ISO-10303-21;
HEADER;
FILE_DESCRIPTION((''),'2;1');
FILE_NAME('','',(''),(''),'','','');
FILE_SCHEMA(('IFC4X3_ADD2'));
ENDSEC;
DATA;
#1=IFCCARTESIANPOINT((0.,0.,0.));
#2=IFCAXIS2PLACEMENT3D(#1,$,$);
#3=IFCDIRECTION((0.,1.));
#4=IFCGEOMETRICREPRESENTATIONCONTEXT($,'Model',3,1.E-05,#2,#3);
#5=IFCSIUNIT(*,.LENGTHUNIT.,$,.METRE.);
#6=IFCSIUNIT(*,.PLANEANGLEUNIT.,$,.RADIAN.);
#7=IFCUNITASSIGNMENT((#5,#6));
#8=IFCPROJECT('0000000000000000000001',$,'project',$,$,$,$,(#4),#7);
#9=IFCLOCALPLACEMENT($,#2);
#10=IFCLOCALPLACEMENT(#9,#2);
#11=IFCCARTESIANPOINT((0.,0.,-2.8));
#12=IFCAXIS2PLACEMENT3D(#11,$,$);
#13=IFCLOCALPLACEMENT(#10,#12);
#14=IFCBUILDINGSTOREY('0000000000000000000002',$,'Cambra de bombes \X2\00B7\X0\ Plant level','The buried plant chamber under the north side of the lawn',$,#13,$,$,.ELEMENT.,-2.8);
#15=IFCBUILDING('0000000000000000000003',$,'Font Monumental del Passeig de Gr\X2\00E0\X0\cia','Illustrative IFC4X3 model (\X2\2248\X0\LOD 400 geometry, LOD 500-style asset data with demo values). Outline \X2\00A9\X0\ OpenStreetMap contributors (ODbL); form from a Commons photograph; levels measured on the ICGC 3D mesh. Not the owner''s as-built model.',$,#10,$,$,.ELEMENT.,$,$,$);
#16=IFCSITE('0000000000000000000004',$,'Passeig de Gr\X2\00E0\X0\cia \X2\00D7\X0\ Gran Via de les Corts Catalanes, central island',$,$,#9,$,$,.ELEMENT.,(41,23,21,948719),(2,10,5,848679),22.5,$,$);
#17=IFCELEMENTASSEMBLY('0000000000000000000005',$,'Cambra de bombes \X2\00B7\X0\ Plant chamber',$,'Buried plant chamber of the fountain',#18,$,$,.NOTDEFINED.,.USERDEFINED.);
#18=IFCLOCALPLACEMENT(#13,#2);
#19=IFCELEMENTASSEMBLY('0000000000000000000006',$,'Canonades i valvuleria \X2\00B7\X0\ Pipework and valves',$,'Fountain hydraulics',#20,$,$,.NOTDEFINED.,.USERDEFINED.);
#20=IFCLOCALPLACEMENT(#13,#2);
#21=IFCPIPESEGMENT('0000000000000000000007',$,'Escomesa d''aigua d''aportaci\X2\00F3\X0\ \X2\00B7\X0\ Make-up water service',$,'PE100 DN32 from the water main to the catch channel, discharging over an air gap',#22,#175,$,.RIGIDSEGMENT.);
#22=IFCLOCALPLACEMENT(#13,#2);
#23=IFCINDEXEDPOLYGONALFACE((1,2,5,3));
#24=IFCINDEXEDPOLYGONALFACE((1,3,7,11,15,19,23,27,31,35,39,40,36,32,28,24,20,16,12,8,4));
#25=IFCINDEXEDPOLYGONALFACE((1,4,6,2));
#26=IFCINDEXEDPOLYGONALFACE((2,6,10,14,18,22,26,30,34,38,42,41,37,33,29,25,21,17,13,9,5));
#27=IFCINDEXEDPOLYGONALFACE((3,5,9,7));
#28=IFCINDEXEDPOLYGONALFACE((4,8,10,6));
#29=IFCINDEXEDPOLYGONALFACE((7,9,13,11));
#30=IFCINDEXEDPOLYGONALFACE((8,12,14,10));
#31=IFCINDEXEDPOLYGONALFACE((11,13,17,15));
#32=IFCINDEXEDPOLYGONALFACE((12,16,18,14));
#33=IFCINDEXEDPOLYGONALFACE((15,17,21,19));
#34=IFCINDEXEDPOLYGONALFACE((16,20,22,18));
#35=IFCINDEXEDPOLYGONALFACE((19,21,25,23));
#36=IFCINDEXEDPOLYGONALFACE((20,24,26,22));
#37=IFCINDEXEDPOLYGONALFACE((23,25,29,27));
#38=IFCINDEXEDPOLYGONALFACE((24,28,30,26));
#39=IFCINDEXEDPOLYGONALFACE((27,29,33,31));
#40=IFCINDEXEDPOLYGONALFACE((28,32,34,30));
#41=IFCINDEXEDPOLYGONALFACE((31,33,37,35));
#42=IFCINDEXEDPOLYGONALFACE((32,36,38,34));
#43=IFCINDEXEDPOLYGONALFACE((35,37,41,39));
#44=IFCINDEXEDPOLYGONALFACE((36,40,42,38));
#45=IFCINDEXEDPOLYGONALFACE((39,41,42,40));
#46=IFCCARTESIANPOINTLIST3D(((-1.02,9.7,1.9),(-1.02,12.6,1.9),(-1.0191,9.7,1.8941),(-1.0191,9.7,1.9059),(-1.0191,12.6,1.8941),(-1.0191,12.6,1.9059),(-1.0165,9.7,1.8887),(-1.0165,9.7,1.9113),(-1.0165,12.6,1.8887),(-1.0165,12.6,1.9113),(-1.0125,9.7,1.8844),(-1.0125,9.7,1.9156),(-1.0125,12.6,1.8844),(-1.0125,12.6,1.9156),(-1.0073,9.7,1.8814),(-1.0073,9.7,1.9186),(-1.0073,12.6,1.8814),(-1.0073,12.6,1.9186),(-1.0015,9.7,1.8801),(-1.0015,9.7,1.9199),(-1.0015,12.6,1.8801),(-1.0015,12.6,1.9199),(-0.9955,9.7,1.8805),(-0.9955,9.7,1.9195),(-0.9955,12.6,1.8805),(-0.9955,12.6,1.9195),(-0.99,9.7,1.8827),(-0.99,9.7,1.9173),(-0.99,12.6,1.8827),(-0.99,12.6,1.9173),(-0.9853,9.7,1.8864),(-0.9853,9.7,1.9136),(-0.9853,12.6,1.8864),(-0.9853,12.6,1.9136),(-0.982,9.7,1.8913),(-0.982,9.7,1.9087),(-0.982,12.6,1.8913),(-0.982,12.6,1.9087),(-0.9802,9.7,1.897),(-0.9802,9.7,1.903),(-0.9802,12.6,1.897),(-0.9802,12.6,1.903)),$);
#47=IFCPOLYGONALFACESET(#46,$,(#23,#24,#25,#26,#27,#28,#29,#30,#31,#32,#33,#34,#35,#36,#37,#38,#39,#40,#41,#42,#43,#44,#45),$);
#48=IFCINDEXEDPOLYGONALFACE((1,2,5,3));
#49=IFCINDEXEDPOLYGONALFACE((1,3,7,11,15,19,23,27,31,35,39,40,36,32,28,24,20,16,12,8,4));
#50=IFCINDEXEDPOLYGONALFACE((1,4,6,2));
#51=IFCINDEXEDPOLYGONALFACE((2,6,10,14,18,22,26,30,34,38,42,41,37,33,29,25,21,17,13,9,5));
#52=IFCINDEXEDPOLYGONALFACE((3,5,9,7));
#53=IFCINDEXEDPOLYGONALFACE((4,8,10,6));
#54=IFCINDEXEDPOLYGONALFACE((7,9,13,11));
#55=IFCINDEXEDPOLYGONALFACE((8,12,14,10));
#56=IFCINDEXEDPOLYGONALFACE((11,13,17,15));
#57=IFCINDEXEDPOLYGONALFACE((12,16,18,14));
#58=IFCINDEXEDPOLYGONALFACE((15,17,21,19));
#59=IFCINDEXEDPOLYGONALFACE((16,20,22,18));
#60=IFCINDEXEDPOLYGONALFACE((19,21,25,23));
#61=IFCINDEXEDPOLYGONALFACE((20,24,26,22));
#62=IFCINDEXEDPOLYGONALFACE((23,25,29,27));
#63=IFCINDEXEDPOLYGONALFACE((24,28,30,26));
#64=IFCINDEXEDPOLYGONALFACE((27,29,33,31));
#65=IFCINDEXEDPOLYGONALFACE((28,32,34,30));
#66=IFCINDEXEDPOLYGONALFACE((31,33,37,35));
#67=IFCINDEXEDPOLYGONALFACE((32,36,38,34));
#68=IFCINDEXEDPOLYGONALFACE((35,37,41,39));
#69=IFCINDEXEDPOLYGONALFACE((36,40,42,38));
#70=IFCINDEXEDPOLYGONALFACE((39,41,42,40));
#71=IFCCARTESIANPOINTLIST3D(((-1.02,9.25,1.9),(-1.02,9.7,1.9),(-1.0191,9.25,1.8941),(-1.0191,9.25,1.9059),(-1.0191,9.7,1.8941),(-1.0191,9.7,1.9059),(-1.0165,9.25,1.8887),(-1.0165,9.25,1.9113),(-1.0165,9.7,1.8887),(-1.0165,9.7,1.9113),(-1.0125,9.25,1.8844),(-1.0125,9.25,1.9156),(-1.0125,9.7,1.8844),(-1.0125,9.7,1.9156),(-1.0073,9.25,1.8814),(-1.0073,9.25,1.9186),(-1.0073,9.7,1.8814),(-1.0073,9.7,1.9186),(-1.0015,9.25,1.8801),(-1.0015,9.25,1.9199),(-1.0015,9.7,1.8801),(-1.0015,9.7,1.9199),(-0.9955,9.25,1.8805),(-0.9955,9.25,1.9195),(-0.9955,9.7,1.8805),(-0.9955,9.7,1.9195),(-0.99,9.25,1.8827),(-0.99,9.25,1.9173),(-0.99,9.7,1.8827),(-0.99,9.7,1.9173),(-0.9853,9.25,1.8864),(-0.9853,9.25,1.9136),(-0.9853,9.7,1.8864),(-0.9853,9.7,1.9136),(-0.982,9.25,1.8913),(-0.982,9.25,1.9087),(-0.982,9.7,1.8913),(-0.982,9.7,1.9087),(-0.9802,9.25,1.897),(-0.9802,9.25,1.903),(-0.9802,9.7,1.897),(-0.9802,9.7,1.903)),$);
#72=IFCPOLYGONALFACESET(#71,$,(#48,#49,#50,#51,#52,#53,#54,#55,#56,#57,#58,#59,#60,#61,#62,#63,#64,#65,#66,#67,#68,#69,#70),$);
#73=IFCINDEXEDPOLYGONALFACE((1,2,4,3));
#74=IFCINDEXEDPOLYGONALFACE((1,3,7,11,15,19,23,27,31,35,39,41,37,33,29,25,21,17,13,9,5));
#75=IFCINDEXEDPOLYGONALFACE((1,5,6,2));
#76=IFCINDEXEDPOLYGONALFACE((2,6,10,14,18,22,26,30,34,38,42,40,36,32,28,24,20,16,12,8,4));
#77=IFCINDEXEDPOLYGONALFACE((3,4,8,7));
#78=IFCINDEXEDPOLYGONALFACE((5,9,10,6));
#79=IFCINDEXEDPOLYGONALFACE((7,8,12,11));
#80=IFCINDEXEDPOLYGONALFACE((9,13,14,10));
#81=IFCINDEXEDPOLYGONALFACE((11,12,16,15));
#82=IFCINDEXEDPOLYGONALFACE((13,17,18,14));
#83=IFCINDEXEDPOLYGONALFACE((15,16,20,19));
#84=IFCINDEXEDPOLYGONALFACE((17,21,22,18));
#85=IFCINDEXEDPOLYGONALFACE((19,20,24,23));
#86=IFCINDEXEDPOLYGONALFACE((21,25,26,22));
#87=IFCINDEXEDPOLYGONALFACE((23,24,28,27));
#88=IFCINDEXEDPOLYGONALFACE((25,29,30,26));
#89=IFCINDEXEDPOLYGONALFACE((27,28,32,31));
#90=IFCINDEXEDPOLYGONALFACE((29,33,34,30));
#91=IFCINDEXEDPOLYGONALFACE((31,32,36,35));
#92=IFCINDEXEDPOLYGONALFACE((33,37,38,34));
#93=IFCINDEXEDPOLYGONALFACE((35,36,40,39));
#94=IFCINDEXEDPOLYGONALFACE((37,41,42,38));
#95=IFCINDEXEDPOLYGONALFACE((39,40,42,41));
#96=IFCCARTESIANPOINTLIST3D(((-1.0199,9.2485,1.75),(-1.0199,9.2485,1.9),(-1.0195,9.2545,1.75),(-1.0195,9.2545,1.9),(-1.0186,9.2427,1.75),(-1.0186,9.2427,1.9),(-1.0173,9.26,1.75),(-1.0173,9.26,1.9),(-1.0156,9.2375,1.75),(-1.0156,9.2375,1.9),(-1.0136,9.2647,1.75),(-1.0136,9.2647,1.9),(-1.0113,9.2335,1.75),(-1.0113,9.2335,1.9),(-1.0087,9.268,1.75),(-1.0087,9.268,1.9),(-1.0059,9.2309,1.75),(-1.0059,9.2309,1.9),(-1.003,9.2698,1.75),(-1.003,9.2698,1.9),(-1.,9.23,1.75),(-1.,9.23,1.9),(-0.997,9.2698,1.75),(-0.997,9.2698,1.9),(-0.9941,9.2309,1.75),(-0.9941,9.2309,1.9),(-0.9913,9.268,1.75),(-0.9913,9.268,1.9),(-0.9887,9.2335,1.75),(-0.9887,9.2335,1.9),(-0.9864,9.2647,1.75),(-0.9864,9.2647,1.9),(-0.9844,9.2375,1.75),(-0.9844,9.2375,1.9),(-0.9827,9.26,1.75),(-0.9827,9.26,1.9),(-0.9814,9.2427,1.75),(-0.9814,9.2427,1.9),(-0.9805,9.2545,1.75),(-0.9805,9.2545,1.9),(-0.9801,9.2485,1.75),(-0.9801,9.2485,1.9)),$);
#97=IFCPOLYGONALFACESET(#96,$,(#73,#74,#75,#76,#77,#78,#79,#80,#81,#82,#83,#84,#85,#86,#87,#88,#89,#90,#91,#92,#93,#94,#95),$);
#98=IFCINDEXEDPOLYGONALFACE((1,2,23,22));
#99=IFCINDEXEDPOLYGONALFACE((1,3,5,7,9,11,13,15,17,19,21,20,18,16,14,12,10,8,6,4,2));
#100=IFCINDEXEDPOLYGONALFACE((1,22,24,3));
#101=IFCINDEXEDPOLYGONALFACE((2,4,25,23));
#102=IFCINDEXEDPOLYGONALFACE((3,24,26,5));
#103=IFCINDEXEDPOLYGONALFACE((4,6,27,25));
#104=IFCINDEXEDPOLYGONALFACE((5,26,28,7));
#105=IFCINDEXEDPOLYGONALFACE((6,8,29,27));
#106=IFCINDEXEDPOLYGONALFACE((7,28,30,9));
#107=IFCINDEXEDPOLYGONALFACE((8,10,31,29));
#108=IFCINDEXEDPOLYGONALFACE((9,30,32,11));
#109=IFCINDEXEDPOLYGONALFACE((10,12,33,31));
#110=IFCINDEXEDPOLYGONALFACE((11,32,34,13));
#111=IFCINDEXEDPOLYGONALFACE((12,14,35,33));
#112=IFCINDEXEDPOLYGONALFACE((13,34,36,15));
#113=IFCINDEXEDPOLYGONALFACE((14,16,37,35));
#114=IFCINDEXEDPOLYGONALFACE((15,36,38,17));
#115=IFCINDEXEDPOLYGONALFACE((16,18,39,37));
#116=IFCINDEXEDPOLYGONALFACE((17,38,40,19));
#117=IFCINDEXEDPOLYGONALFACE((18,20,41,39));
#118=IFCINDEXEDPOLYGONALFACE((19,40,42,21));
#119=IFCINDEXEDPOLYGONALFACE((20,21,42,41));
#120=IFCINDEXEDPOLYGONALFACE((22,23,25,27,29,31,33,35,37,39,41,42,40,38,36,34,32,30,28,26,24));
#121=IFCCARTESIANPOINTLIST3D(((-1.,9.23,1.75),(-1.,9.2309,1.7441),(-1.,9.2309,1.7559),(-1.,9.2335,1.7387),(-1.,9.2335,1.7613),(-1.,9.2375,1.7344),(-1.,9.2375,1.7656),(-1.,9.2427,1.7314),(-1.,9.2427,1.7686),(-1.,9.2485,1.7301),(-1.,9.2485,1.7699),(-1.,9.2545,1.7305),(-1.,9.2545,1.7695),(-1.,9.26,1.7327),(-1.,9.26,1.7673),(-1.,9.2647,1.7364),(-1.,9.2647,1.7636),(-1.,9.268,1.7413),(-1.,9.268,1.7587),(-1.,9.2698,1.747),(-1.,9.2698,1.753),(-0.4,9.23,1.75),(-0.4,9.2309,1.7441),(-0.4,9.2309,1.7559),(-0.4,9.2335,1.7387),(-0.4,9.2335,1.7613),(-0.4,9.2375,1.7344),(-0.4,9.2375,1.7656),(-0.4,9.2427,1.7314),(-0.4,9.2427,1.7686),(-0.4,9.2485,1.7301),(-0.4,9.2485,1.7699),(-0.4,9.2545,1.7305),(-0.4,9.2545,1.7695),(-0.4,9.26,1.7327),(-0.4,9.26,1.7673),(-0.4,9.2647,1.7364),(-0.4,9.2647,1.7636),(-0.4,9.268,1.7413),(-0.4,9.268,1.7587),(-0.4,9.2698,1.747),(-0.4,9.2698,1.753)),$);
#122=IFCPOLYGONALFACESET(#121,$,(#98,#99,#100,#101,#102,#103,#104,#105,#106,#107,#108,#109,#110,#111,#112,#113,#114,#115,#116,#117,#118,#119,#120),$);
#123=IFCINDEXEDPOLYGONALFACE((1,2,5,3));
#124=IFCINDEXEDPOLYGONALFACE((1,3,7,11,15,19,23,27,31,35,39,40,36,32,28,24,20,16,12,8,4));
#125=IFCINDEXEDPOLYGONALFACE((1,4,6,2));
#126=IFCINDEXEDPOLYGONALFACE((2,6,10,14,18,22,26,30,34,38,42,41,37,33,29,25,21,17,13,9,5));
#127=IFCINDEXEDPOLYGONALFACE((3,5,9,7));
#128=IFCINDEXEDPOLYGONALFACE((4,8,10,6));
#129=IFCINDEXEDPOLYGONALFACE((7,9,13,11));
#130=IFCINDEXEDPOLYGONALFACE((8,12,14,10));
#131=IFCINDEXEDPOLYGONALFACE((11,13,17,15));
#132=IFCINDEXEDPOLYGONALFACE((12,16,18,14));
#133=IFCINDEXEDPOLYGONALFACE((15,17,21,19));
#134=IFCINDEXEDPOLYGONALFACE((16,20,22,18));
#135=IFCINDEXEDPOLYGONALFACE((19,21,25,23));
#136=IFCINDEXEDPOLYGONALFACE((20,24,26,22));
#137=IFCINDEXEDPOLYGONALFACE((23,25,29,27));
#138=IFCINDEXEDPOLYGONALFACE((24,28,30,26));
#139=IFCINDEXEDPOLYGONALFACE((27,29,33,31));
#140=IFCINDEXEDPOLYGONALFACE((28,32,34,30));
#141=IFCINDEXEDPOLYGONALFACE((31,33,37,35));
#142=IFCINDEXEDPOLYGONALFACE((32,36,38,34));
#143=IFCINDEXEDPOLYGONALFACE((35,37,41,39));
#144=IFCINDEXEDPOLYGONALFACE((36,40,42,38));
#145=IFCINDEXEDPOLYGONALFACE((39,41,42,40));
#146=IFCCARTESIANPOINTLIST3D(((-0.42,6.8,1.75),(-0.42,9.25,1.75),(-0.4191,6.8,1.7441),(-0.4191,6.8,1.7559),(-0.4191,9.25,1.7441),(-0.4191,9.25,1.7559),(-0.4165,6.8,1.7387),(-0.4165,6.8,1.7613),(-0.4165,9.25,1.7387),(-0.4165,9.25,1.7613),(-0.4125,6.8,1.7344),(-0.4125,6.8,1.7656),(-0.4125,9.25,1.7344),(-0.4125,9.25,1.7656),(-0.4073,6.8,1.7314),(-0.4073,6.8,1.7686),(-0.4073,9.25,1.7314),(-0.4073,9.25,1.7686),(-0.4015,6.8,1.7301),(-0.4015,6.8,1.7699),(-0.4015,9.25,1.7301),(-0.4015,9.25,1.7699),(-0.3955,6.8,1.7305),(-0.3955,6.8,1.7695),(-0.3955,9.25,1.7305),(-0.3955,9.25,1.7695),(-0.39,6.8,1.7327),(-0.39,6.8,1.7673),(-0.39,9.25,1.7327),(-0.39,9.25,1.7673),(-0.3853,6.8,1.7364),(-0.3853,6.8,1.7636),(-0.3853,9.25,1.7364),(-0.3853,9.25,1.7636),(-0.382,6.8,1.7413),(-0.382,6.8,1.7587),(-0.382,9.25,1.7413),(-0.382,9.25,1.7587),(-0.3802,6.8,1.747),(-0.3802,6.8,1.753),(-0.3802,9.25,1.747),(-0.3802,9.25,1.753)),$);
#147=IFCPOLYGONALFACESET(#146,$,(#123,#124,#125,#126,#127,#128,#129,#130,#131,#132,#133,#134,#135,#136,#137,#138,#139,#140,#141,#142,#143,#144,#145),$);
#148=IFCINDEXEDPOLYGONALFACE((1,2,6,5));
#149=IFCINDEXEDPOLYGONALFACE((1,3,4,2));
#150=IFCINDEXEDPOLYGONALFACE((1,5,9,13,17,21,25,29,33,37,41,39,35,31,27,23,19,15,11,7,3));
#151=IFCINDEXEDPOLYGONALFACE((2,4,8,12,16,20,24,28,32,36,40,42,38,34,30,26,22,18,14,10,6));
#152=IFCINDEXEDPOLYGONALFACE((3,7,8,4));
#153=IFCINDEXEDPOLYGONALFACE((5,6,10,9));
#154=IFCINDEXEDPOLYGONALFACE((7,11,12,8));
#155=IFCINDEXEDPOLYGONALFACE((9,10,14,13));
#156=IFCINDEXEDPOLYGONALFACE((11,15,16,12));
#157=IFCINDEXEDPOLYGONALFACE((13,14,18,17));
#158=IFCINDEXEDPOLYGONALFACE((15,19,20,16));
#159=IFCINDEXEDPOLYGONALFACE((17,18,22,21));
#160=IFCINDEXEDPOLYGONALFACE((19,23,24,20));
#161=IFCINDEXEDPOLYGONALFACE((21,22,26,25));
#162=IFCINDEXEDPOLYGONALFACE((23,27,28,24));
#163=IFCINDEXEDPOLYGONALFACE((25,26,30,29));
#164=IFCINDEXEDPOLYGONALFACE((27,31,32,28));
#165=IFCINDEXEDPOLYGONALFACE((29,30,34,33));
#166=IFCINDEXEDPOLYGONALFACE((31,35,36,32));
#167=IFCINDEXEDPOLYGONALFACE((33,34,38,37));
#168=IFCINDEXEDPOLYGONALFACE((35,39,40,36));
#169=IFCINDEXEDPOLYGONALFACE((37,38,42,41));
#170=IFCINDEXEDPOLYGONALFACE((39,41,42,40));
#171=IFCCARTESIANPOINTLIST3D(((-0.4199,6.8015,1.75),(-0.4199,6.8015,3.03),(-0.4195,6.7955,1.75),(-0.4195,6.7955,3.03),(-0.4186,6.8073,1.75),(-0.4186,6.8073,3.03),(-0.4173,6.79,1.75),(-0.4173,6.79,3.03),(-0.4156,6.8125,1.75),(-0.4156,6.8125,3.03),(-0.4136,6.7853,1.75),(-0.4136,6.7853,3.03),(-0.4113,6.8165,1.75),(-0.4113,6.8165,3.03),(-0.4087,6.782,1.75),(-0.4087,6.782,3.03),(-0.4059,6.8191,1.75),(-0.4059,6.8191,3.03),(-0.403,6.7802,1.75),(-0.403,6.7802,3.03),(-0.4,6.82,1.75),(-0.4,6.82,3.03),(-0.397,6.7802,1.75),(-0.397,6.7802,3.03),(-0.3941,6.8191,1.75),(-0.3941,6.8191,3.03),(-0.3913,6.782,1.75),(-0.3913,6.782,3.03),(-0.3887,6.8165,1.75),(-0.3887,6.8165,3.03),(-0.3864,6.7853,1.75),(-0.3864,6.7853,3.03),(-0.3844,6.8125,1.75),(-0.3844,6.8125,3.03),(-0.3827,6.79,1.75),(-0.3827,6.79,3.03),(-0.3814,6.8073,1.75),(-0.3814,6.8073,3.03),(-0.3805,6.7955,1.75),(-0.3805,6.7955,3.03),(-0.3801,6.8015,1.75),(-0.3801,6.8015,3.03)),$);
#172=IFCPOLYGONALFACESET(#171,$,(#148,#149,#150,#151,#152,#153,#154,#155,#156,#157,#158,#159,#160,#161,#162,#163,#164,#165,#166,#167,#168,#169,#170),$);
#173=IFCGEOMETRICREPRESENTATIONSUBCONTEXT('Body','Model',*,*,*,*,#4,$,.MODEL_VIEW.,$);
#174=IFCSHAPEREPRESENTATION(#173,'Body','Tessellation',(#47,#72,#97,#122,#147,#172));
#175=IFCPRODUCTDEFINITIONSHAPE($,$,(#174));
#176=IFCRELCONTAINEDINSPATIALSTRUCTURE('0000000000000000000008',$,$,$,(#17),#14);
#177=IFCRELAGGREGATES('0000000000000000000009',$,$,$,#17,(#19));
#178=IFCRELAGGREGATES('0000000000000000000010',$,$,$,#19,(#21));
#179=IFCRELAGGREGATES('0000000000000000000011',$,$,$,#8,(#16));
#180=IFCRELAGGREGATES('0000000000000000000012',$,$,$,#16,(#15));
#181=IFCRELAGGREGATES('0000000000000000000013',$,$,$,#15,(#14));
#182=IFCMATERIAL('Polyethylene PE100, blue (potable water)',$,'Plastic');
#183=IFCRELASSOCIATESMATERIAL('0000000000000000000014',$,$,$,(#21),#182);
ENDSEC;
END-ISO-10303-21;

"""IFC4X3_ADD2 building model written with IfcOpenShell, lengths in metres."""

from ifc_helpers import new_model, si_unit, direction, frame, origin, origin_2d_with_axis, place, context, subcontext, project, spatial, circle, extrude, material, element, aggregate, save


model = new_model("IFC4X3_ADD2")

# Units and contexts
model_context = context("Model", 3, precision=1e-05, world=origin(), true_north=direction((0.0, 1.0)))
body_context = subcontext(model_context, "Body", "Model", "MODEL_VIEW")
ifc_project = project(units=[si_unit("LENGTHUNIT", "METRE"), si_unit("PLANEANGLEUNIT", "RADIAN")], contexts=[model_context])

# Site, building, storey
site_placement = place(None, origin())
site = spatial("IfcSite", under=ifc_project, at=site_placement, Name="Passeig de Gràcia × Gran Via de les Corts Catalanes, central island", CompositionType="ELEMENT", RefLatitude=(41, 23, 21, 948719), RefLongitude=(2, 10, 5, 848679), RefElevation=22.5)
building_placement = place(site_placement, origin())
building = spatial("IfcBuilding", under=site, at=building_placement, Name="Font Monumental del Passeig de Gràcia", Description="Illustrative IFC4X3 model (≈LOD 400 geometry, LOD 500-style asset data with demo values). Outline © OpenStreetMap contributors (ODbL); form from a Commons photograph; levels measured on the ICGC 3D mesh. Not the owner's as-built model.", CompositionType="ELEMENT")
storey_placement = place(building_placement, frame((0.0, 0.0, -2.8)))
storey = spatial("IfcBuildingStorey", under=building, at=storey_placement, Name="Cambra de bombes · Plant level", Description="The buried plant chamber under the north side of the lawn", CompositionType="ELEMENT", Elevation=-2.8)

# Element assemblies, pipe segment
assembly_1_placement = place(building_placement, origin())
assembly_1 = element("IfcElementAssembly", 1, at=assembly_1_placement, inside=storey, Name="Cambra de bombes · Plant chamber", ObjectType="Buried plant chamber of the fountain", AssemblyPlace="NOTDEFINED", PredefinedType="USERDEFINED")
assembly_2_placement = place(building_placement, origin())
assembly_2 = element("IfcElementAssembly", 2, at=assembly_2_placement, Name="Canonades i valvuleria · Pipework and valves", ObjectType="Fountain hydraulics", AssemblyPlace="NOTDEFINED", PredefinedType="USERDEFINED")
aggregate(assembly_1, [assembly_2])
ifc_material_1 = material(Name="Polyethylene PE100, blue (potable water)", Category="Plastic")
pipe_segment_1_placement = place(building_placement, origin())
pipe_segment_1 = element("IfcPipeSegment", 3, at=pipe_segment_1_placement, material=ifc_material_1, Name="Escomesa d'aigua d'aportació · Make-up water service", ObjectType="PE100 DN32 from the water main to the catch channel, discharging over an air gap", PredefinedType="RIGIDSEGMENT", context=body_context, shape_type="SweptSolid", body=[
    extrude(circle(Radius=0.02, at=origin_2d_with_axis()), frame((-1.0, 12.6, -0.9), z_axis=(0.0, -1.0, 0.0), x_axis=(-1.0, 0.0, 0.0)), (0.0, 0.0, 1.0), 2.9),
    extrude(circle(Radius=0.02, at=origin_2d_with_axis()), frame((-1.0, 9.7, -0.9), z_axis=(0.0, -1.0, 0.0), x_axis=(-1.0, 0.0, 0.0)), (0.0, 0.0, 1.0), 0.45),
    extrude(circle(Radius=0.02, at=origin_2d_with_axis()), frame((-1.0, 9.25, -0.9), z_axis=(0.0, 0.0, -1.0), x_axis=(0.0, -1.0, 0.0)), (0.0, 0.0, 1.0), 0.15),
    extrude(circle(Radius=0.02, at=origin_2d_with_axis()), frame((-1.0, 9.25, -1.05), z_axis=(1.0, 0.0, 0.0), x_axis=(0.0, -1.0, 0.0)), (0.0, 0.0, 1.0), 0.6),
    extrude(circle(Radius=0.02, at=origin_2d_with_axis()), frame((-0.4, 9.25, -1.05), z_axis=(0.0, -1.0, 0.0), x_axis=(-1.0, 0.0, 0.0)), (0.0, 0.0, 1.0), 2.45),
    extrude(circle(Radius=0.02, at=origin_2d_with_axis()), frame((-0.4, 6.8, -1.05), z_axis=(0.0, 0.0, 1.0), x_axis=(0.0, 1.0, 0.0)), (0.0, 0.0, 1.0), 1.28),
])
aggregate(assembly_2, [pipe_segment_1])

save(model, "model.ifc")
